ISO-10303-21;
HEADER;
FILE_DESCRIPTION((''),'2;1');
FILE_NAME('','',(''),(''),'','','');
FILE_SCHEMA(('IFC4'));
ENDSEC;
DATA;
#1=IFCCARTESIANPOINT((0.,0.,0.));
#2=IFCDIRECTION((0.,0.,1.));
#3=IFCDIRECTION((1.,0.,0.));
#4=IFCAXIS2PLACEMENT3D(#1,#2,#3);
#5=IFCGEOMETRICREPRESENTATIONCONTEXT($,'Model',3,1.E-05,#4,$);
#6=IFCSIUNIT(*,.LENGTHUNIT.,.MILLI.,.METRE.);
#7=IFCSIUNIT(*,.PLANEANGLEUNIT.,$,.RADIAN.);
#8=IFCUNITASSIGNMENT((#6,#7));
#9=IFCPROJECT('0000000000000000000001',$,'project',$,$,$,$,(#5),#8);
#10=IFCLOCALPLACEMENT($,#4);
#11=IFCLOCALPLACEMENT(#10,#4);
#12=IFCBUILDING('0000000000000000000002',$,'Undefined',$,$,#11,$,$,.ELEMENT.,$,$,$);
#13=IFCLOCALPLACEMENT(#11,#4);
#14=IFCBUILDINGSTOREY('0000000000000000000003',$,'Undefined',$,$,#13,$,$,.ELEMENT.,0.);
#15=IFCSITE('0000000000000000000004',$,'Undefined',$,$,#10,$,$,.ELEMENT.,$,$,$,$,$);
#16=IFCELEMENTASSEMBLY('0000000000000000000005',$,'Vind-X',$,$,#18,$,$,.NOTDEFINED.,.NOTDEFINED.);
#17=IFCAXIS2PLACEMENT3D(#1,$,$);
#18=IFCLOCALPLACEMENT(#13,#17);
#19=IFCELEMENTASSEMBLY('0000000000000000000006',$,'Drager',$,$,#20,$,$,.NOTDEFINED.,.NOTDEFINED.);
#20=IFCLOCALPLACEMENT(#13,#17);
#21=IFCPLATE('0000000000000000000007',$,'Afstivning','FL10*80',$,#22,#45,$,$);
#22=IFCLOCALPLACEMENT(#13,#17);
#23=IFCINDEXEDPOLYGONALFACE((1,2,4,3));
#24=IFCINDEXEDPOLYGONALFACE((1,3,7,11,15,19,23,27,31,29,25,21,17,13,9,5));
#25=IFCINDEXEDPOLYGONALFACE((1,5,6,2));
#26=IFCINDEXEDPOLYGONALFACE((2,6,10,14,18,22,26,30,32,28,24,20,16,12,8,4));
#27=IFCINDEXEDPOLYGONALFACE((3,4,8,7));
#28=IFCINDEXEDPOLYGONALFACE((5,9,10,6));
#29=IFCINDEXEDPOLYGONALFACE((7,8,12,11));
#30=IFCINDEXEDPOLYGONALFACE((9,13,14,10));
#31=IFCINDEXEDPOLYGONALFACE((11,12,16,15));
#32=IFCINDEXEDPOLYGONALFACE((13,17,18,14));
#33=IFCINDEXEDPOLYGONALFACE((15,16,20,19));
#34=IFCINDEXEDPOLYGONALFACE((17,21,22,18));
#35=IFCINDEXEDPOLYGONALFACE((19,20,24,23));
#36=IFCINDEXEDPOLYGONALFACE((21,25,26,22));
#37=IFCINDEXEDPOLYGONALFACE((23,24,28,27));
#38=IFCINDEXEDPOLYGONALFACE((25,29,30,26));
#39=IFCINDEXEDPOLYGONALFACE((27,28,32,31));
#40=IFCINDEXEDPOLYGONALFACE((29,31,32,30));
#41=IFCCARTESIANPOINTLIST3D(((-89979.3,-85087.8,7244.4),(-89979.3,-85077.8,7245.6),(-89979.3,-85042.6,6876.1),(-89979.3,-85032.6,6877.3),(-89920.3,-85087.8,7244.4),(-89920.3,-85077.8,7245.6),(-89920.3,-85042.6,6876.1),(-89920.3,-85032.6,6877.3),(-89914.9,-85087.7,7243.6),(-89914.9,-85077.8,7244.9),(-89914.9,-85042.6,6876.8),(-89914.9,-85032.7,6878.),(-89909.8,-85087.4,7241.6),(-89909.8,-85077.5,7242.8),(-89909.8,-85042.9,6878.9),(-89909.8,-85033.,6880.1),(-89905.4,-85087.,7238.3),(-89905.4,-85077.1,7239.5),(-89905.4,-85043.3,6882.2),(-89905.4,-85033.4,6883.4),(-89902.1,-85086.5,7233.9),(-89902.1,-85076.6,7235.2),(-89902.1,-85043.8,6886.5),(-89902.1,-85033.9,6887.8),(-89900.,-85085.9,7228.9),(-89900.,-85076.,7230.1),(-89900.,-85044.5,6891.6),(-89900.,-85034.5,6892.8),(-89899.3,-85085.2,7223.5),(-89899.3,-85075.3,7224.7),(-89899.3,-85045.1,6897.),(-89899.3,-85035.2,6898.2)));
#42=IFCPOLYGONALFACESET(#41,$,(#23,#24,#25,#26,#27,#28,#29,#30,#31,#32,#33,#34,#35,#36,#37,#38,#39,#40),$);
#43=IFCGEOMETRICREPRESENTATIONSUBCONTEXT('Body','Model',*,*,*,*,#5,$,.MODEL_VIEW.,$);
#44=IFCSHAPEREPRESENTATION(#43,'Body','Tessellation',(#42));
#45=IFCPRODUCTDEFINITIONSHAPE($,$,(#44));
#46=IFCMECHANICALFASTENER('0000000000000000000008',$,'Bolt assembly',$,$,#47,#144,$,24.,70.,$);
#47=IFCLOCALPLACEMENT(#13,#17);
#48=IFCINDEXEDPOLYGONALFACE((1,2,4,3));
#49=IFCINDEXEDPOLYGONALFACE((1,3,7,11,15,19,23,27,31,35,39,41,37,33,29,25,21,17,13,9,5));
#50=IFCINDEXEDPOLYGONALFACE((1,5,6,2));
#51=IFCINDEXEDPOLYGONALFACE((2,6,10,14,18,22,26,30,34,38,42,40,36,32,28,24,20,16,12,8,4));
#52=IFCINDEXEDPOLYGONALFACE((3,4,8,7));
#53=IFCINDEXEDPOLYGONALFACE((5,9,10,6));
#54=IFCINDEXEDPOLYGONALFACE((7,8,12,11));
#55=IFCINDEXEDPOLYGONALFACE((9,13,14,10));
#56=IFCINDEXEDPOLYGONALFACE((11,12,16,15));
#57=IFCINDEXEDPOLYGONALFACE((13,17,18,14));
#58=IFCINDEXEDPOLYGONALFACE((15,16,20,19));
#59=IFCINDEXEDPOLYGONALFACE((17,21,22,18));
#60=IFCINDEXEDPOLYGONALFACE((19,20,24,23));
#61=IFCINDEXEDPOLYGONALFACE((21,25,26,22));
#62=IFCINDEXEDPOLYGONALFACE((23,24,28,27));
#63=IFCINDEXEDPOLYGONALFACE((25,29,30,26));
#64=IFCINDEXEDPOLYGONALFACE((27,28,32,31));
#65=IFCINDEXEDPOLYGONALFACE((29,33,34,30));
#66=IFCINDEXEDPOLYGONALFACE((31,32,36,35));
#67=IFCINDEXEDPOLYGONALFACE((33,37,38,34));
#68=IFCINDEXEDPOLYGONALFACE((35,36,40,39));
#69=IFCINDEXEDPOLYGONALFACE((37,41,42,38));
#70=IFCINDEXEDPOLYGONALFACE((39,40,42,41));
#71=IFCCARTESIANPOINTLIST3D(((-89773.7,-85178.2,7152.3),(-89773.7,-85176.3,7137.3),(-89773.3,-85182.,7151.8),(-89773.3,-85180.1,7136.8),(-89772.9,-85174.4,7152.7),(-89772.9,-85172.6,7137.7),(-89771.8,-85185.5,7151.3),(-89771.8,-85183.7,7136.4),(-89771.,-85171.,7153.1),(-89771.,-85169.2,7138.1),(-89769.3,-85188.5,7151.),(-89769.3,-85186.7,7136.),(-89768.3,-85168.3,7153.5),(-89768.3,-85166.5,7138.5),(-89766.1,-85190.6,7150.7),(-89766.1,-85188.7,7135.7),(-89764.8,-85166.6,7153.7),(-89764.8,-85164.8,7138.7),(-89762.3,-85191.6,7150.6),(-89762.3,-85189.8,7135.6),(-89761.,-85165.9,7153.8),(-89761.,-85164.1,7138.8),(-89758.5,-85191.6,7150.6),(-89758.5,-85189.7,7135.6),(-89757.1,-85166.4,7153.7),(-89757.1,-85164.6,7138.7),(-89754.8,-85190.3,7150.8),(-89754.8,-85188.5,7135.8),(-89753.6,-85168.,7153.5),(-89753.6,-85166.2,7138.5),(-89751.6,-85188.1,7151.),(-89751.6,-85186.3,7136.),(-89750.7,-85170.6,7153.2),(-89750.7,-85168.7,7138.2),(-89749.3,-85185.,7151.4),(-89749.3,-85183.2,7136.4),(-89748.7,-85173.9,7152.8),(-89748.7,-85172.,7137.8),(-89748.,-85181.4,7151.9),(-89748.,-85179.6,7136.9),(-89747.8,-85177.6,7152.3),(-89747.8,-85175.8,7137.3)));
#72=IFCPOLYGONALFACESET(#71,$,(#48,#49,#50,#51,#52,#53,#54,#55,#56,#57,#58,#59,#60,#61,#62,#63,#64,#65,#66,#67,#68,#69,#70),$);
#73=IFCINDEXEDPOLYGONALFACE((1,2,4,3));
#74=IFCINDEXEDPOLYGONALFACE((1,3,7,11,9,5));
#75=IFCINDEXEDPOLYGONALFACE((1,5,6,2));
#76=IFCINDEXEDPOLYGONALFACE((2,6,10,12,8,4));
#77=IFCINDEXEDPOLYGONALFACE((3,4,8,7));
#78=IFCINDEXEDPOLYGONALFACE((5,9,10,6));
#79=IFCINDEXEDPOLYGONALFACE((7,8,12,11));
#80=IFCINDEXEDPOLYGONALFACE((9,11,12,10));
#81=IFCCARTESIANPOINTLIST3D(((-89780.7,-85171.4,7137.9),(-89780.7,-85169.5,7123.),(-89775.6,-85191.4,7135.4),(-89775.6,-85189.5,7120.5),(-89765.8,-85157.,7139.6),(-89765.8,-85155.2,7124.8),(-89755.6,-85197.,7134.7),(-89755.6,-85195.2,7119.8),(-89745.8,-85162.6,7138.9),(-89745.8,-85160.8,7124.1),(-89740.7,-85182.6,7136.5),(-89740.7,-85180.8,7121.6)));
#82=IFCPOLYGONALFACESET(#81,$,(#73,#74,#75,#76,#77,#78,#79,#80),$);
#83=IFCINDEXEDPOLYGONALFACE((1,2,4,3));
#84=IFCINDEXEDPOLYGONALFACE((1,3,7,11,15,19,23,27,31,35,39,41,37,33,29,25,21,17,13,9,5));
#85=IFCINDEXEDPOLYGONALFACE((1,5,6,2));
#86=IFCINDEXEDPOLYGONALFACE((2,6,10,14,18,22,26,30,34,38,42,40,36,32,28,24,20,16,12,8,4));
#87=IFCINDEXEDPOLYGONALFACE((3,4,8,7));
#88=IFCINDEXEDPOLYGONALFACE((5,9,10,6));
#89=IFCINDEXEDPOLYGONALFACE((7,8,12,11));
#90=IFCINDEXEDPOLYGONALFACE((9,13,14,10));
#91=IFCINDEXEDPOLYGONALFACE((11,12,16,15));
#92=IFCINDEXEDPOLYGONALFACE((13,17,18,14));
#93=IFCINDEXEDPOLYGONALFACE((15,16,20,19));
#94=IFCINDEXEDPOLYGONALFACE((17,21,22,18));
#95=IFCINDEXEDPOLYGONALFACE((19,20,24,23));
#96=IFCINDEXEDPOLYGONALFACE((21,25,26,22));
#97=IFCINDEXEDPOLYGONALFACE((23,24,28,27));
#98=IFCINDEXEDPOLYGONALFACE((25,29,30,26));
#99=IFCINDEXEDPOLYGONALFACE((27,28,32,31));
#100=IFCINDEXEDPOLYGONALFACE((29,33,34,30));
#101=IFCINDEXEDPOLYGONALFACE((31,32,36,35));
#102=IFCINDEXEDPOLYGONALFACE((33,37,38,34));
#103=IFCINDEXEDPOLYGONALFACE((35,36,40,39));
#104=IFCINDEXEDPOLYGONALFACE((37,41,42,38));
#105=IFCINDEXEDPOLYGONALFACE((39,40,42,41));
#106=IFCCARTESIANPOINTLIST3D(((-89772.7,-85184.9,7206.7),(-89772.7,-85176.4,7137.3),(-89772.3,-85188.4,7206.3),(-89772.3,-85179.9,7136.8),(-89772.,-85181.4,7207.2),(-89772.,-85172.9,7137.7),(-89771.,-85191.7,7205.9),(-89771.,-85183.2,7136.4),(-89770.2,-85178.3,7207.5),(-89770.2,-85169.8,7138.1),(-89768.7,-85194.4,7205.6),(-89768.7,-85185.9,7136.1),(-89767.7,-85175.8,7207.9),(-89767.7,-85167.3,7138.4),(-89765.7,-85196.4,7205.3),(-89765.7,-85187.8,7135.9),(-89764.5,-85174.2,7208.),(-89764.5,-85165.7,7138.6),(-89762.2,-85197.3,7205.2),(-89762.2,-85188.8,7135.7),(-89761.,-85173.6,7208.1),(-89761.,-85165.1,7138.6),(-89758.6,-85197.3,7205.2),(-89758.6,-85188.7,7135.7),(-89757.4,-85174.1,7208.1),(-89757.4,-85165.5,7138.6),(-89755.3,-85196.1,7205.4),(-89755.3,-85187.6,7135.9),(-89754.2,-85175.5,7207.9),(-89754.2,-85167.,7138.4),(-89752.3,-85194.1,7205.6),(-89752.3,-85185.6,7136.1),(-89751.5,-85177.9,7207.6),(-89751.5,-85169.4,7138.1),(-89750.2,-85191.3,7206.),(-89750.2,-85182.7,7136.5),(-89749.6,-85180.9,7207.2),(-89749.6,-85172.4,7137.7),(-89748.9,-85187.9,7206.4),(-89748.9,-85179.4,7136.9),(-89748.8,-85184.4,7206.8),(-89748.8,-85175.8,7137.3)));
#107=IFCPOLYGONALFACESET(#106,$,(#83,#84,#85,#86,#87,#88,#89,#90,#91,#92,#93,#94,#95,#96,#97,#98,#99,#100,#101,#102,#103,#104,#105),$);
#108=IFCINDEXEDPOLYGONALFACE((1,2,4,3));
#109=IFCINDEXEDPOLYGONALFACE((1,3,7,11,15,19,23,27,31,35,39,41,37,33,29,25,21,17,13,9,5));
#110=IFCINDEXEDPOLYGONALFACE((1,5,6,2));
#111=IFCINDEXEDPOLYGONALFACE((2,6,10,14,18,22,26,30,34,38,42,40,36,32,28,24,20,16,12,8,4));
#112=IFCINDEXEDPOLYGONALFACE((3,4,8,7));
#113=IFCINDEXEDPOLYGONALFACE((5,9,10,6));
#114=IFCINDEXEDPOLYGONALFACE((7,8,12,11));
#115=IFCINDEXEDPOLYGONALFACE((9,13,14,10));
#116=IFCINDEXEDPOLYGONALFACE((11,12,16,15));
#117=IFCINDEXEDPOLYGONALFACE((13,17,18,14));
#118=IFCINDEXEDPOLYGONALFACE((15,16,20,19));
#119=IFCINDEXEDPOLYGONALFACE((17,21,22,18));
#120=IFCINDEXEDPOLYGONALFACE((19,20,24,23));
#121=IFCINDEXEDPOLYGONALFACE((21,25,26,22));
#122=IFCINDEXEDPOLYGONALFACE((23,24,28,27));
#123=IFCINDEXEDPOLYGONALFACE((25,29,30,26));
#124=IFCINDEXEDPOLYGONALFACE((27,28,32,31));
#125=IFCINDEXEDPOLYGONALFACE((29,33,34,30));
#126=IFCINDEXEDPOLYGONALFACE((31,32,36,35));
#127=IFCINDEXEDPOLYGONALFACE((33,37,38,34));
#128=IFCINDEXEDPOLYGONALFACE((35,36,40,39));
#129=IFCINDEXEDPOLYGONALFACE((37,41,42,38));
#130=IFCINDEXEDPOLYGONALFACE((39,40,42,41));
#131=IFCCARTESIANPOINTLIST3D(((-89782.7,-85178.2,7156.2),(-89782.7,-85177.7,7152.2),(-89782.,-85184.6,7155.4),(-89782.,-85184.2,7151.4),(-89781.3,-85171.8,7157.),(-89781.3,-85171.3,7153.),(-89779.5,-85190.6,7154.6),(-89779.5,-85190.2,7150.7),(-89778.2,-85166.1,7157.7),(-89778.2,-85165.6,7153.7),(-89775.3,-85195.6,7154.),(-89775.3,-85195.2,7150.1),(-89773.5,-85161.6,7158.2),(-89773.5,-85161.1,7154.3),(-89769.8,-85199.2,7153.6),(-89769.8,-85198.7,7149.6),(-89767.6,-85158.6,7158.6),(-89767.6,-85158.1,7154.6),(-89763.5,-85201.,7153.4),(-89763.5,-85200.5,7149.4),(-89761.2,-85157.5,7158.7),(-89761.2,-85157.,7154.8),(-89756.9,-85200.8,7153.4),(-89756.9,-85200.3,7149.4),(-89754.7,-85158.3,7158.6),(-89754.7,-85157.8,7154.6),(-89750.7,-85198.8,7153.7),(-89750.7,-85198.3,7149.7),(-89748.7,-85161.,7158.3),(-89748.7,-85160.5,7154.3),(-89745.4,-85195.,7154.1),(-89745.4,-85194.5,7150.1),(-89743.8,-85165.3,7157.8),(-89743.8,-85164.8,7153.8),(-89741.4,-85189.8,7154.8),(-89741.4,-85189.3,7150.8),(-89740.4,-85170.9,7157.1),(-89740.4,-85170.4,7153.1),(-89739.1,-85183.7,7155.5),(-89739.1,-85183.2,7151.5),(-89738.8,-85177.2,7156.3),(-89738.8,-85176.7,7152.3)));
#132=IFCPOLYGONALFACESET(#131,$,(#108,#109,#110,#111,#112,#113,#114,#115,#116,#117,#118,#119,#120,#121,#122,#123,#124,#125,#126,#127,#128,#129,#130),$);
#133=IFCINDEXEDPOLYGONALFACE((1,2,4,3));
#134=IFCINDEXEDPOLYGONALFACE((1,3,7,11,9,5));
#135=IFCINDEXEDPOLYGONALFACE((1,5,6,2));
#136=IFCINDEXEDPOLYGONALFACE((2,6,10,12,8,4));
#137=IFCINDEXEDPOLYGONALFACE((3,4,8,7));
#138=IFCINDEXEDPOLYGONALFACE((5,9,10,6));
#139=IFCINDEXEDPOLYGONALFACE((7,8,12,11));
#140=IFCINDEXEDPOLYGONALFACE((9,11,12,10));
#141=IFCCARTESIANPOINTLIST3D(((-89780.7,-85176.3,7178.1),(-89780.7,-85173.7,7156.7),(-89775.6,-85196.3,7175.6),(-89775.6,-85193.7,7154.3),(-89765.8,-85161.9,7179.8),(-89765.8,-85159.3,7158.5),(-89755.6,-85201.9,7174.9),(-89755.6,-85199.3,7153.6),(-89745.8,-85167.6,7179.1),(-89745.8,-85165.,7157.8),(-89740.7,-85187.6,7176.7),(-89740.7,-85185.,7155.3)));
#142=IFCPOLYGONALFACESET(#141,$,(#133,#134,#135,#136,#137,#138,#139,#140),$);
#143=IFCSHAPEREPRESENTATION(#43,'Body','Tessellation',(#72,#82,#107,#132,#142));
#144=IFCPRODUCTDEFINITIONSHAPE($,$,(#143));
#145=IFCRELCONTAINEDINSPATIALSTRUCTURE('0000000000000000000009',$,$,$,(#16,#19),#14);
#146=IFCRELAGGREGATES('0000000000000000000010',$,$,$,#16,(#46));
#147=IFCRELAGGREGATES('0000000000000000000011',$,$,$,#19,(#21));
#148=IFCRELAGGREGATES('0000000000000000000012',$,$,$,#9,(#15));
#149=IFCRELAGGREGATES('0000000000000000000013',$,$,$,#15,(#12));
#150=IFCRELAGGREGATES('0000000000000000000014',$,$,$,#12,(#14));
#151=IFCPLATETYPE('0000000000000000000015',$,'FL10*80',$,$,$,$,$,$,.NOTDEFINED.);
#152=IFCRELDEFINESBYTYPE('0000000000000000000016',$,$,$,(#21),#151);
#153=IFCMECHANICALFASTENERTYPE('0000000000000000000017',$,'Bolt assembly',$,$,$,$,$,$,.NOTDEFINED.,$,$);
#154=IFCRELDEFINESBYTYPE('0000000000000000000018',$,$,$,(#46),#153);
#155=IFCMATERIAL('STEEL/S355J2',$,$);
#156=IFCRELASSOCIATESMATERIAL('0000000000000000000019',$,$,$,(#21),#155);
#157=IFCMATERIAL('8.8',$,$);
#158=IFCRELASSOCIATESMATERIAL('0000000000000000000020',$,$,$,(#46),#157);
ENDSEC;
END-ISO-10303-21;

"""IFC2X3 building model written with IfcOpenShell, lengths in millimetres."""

from ifc_helpers import new_model, si_unit, frame, frame_2d, origin_with_axes, origin_2d_with_axis, place, context, subcontext, project, spatial, polyline, circle_curve, parameter, trimmed, segment, composite_curve, circle, outline, extrude, source, transform, mapped, material, type_object, element, aggregate, save


model = new_model("IFC2X3")

# Units and contexts
model_context = context("Model", 3, precision=1e-05, world=origin_with_axes())
body_context = subcontext(model_context, "Body", "Model", "MODEL_VIEW")
ifc_project = project(units=[si_unit("LENGTHUNIT", "METRE", prefix="MILLI"), si_unit("PLANEANGLEUNIT", "RADIAN")], contexts=[model_context])

# Site, building, storey
site_placement = place(None, origin_with_axes())
site = spatial("IfcSite", under=ifc_project, at=site_placement, Name="Undefined", CompositionType="ELEMENT")
building_placement = place(site_placement, origin_with_axes())
building = spatial("IfcBuilding", under=site, at=building_placement, Name="Undefined", CompositionType="ELEMENT")
storey_placement = place(building_placement, origin_with_axes())
storey = spatial("IfcBuildingStorey", under=building, at=storey_placement, Name="Undefined", CompositionType="ELEMENT", Elevation=0.0)

# Shared definitions
ifc_material_1 = material(Name="STEEL/S355J2")

# Element assembly
assembly_1_placement = place(storey_placement, origin_with_axes())
assembly_1 = element("IfcElementAssembly", 1, at=assembly_1_placement, inside=storey, Name="Vind-X", AssemblyPlace="NOTDEFINED", PredefinedType="NOTDEFINED")

# Element assembly
assembly_2_placement = place(storey_placement, origin_with_axes())
assembly_2 = element("IfcElementAssembly", 2, at=assembly_2_placement, inside=storey, Name="Drager", AssemblyPlace="NOTDEFINED", PredefinedType="NOTDEFINED")

# Plate
plate_type_1 = type_object("IfcPlateType", Name="FL10*80", PredefinedType="NOTDEFINED")
plate_1_placement = place(assembly_2_placement, frame((-89979.3, -85037.6, 6876.7), z_axis=(0.0, -0.992546, -0.121869), x_axis=(1.0, 0.0, 0.0)))
plate_1 = element("IfcPlate", 3, at=plate_1_placement, type_object=plate_type_1, material=ifc_material_1, Name="Afstivning", Description="FL10*80", context=body_context, shape_type="SweptSolid", body=[
    extrude(outline(composite_curve([segment(polyline([(0.0, 0.0), (59.0, 0.0)]), True, "CONTINUOUS"), segment(trimmed(circle_curve(frame_2d((59.0, 21.0), x_axis=(0.0, -1.0)), 21.0), [parameter(0.0)], [parameter(1.570796)], True, "PARAMETER"), True, "CONTINUOUS"), segment(polyline([(80.0, 21.0), (80.0, 350.0)]), True, "CONTINUOUS"), segment(trimmed(circle_curve(frame_2d((59.0, 350.0), x_axis=(1.0, 0.0)), 21.0), [parameter(0.0)], [parameter(1.570796)], True, "PARAMETER"), True, "CONTINUOUS"), segment(polyline([(59.0, 371.0), (0.0, 371.0), (0.0, 0.0)]), True, "CONTINUOUS")], self_intersect=True)), frame((0.0, 0.0, -5.0), z_axis=(0.0, 0.0, 1.0), x_axis=(1.0, 0.0, 0.0)), (0.0, 0.0, 1.0), 10.0),
])

# Mechanical fastener
ifc_material_2 = material(Name="8.8")
mechanical_fastener_type = type_object("IfcMechanicalFastenerType", Name="Bolt assembly")
shared_shape_1 = source(origin_with_axes(), body_context, "Body", "SweptSolid", [
    extrude(circle(Radius=13.0, at=origin_2d_with_axis()), frame((0.0, 0.0, 0.0), z_axis=(0.0, 1.0, 0.0), x_axis=(1.0, 0.0, 0.0)), (0.0, 0.0, 1.0), 15.1),
    extrude(outline(polyline([(18.0, -10.4), (18.0, 10.4), (0.0, 20.8), (-18.0, 10.4), (-18.0, -10.4), (0.0, -20.8), (18.0, -10.4)])), frame((0.0, -15.0, 0.0), z_axis=(0.0, 1.0, 0.0), x_axis=(1.0, 0.0, 0.0)), (0.0, 0.0, 1.0), 15.0),
    extrude(circle(Radius=12.0, at=origin_2d_with_axis()), frame((0.0, 0.0, 0.0), z_axis=(0.0, 1.0, 0.0), x_axis=(1.0, 0.0, 0.0)), (0.0, 0.0, 1.0), 70.0),
    extrude(circle(Radius=22.0, at=origin_2d_with_axis()), frame((0.0, 15.0, 0.0), z_axis=(0.0, 1.0, 0.0), x_axis=(1.0, 0.0, 0.0)), (0.0, 0.0, 1.0), 4.0),
    extrude(outline(polyline([(18.0, -10.4), (18.0, 10.4), (0.0, 20.8), (-18.0, 10.4), (-18.0, -10.4), (0.0, -20.8), (18.0, -10.4)])), frame((0.0, 19.0, 0.0), z_axis=(0.0, 1.0, 0.0), x_axis=(1.0, 0.0, 0.0)), (0.0, 0.0, 1.0), 21.5),
])
mechanical_fastener_1_placement = place(assembly_1_placement, frame((-89760.7, -85177.0, 7137.2), z_axis=(-0.717842, -0.691017, -0.084846), x_axis=(0.696206, -0.712491, -0.087483)))
mechanical_fastener_1 = element("IfcMechanicalFastener", 4, at=mechanical_fastener_1_placement, type_object=mechanical_fastener_type, material=ifc_material_2, Name="Bolt assembly", NominalDiameter=24.0, NominalLength=70.0, context=body_context, shape_type="MappedRepresentation", body=[
    mapped(shared_shape_1, transform((0.0, 0.0, 0.0))),
])
aggregate(assembly_1, [mechanical_fastener_1])
aggregate(assembly_2, [plate_1])

save(model, "model.ifc")
